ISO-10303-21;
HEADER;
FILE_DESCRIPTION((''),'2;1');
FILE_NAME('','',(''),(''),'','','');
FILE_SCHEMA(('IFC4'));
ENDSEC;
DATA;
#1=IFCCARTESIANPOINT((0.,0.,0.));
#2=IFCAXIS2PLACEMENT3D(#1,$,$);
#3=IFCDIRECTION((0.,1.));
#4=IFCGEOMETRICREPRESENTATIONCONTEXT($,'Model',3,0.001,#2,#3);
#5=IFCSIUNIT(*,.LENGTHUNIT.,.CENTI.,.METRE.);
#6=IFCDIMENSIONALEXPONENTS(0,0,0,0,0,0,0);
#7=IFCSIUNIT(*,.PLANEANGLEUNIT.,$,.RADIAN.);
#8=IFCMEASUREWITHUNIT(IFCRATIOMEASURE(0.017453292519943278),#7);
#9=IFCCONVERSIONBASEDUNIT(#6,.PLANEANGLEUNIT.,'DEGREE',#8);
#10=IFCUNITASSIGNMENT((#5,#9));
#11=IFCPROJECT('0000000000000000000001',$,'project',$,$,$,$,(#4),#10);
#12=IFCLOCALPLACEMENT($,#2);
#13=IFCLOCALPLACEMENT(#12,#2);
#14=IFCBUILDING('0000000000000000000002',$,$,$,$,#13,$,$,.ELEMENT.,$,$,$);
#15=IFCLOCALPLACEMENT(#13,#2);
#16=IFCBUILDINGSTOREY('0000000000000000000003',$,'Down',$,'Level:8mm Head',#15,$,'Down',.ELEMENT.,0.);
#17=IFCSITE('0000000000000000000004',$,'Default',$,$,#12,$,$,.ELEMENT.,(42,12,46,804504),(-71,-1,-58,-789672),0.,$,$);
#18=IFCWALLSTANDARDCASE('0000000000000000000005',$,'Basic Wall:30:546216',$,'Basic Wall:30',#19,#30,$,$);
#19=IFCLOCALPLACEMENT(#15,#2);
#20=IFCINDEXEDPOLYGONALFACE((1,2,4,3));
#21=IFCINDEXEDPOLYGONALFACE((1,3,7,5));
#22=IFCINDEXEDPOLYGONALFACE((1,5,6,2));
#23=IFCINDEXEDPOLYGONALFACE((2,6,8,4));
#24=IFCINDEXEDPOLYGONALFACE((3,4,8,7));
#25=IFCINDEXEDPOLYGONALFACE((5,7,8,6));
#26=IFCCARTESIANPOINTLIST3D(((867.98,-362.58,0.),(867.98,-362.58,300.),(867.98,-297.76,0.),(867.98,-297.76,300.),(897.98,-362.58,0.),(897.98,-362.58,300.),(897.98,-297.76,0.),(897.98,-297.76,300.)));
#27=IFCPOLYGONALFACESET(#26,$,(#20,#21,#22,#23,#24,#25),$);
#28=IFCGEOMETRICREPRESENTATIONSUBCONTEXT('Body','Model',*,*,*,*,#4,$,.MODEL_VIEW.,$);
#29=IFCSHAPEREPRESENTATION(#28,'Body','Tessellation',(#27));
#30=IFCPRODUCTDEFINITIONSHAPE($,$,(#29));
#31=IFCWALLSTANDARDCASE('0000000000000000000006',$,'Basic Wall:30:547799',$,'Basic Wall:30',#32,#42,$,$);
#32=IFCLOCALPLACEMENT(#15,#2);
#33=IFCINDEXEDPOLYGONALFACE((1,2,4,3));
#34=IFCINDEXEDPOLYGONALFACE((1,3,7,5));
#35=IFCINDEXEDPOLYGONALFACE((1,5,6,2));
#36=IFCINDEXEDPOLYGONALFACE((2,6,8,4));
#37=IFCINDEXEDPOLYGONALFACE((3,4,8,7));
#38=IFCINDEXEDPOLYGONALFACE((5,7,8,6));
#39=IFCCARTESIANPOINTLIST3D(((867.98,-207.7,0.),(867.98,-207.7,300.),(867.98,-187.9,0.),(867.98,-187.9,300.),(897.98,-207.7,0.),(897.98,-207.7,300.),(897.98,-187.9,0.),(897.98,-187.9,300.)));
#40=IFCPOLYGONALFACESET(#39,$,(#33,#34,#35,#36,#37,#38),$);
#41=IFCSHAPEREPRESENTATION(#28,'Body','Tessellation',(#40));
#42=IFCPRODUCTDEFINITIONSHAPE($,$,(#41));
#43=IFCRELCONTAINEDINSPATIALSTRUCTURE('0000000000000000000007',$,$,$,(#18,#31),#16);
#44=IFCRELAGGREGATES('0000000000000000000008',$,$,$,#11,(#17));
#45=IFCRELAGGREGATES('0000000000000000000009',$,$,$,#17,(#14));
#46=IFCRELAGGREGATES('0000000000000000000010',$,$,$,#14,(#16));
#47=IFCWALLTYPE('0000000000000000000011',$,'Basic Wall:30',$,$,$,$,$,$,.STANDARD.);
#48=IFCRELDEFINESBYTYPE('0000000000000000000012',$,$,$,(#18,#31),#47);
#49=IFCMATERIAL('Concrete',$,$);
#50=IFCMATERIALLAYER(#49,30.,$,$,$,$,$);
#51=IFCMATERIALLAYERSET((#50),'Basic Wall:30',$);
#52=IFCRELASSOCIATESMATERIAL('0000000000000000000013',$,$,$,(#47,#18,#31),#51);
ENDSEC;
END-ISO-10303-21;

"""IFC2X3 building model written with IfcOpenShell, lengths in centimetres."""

from ifc_helpers import new_model, entity, si_unit, converted_unit, direction, frame, frame_2d, origin, place, context, subcontext, project, spatial, rectangle, extrude, material, layer, layer_set, layer_usage, type_object, element, save


model = new_model("IFC2X3")

# Units and contexts
model_context = context("Model", 3, precision=0.001, world=origin(), true_north=direction((0.0, 1.0)))
body_context = subcontext(model_context, "Body", "Model", "MODEL_VIEW")
ifc_project = project(units=[si_unit("LENGTHUNIT", "METRE", prefix="CENTI"), converted_unit("PLANEANGLEUNIT", "DEGREE", entity("IfcRatioMeasure", 0.017453292519943278), si_unit("PLANEANGLEUNIT", "RADIAN"), dimensions=[0, 0, 0, 0, 0, 0, 0])], contexts=[model_context])

# Site, building, storey
site_placement = place(None, origin())
site = spatial("IfcSite", under=ifc_project, at=site_placement, Name="Default", CompositionType="ELEMENT", RefLatitude=(42, 12, 46, 804504), RefLongitude=(-71, -1, -58, -789672), RefElevation=0.0)
building_placement = place(site_placement, origin())
building = spatial("IfcBuilding", under=site, at=building_placement, CompositionType="ELEMENT")
storey_placement = place(building_placement, origin())
storey = spatial("IfcBuildingStorey", under=building, at=storey_placement, Name="Down", ObjectType="Level:8mm Head", LongName="Down", CompositionType="ELEMENT", Elevation=0.0)

# Walls
ifc_material = material(Name="Concrete")
ifc_layer_1 = layer(ifc_material, 30.0)
ifc_layer_set_1 = layer_set([ifc_layer_1], Name="Basic Wall:30")
ifc_layer_usage_1 = layer_usage(ifc_layer_set_1, "AXIS2", "NEGATIVE", 15.0)
wall_type_1 = type_object("IfcWallType", Name="Basic Wall:30", PredefinedType="STANDARD", material=ifc_layer_set_1)
wall_1_placement = place(storey_placement, frame((882.98, -297.76, 0.0), z_axis=(0.0, 0.0, 1.0), x_axis=(0.0, -1.0, 0.0)))
element("IfcWallStandardCase", 1, at=wall_1_placement, inside=storey, type_object=wall_type_1, material=ifc_layer_usage_1, Name="Basic Wall:30:546216", ObjectType="Basic Wall:30", context=body_context, shape_type="SweptSolid", body=[
    extrude(rectangle(XDim=64.82, YDim=30.0, at=frame_2d((32.41, 0.0), x_axis=(-1.0, 0.0))), origin(), (0.0, 0.0, 1.0), 300.0),
])
ifc_layer_usage_2 = layer_usage(ifc_layer_set_1, "AXIS2", "NEGATIVE", 15.0)
wall_2_placement = place(storey_placement, frame((882.98, -187.9, 0.0), z_axis=(0.0, 0.0, 1.0), x_axis=(0.0, -1.0, 0.0)))
element("IfcWallStandardCase", 2, at=wall_2_placement, inside=storey, type_object=wall_type_1, material=ifc_layer_usage_2, Name="Basic Wall:30:547799", ObjectType="Basic Wall:30", context=body_context, shape_type="SweptSolid", body=[
    extrude(rectangle(XDim=19.8, YDim=30.0, at=frame_2d((9.9, 0.0), x_axis=(-1.0, 0.0))), origin(), (0.0, 0.0, 1.0), 300.0),
])

save(model, "model.ifc")
